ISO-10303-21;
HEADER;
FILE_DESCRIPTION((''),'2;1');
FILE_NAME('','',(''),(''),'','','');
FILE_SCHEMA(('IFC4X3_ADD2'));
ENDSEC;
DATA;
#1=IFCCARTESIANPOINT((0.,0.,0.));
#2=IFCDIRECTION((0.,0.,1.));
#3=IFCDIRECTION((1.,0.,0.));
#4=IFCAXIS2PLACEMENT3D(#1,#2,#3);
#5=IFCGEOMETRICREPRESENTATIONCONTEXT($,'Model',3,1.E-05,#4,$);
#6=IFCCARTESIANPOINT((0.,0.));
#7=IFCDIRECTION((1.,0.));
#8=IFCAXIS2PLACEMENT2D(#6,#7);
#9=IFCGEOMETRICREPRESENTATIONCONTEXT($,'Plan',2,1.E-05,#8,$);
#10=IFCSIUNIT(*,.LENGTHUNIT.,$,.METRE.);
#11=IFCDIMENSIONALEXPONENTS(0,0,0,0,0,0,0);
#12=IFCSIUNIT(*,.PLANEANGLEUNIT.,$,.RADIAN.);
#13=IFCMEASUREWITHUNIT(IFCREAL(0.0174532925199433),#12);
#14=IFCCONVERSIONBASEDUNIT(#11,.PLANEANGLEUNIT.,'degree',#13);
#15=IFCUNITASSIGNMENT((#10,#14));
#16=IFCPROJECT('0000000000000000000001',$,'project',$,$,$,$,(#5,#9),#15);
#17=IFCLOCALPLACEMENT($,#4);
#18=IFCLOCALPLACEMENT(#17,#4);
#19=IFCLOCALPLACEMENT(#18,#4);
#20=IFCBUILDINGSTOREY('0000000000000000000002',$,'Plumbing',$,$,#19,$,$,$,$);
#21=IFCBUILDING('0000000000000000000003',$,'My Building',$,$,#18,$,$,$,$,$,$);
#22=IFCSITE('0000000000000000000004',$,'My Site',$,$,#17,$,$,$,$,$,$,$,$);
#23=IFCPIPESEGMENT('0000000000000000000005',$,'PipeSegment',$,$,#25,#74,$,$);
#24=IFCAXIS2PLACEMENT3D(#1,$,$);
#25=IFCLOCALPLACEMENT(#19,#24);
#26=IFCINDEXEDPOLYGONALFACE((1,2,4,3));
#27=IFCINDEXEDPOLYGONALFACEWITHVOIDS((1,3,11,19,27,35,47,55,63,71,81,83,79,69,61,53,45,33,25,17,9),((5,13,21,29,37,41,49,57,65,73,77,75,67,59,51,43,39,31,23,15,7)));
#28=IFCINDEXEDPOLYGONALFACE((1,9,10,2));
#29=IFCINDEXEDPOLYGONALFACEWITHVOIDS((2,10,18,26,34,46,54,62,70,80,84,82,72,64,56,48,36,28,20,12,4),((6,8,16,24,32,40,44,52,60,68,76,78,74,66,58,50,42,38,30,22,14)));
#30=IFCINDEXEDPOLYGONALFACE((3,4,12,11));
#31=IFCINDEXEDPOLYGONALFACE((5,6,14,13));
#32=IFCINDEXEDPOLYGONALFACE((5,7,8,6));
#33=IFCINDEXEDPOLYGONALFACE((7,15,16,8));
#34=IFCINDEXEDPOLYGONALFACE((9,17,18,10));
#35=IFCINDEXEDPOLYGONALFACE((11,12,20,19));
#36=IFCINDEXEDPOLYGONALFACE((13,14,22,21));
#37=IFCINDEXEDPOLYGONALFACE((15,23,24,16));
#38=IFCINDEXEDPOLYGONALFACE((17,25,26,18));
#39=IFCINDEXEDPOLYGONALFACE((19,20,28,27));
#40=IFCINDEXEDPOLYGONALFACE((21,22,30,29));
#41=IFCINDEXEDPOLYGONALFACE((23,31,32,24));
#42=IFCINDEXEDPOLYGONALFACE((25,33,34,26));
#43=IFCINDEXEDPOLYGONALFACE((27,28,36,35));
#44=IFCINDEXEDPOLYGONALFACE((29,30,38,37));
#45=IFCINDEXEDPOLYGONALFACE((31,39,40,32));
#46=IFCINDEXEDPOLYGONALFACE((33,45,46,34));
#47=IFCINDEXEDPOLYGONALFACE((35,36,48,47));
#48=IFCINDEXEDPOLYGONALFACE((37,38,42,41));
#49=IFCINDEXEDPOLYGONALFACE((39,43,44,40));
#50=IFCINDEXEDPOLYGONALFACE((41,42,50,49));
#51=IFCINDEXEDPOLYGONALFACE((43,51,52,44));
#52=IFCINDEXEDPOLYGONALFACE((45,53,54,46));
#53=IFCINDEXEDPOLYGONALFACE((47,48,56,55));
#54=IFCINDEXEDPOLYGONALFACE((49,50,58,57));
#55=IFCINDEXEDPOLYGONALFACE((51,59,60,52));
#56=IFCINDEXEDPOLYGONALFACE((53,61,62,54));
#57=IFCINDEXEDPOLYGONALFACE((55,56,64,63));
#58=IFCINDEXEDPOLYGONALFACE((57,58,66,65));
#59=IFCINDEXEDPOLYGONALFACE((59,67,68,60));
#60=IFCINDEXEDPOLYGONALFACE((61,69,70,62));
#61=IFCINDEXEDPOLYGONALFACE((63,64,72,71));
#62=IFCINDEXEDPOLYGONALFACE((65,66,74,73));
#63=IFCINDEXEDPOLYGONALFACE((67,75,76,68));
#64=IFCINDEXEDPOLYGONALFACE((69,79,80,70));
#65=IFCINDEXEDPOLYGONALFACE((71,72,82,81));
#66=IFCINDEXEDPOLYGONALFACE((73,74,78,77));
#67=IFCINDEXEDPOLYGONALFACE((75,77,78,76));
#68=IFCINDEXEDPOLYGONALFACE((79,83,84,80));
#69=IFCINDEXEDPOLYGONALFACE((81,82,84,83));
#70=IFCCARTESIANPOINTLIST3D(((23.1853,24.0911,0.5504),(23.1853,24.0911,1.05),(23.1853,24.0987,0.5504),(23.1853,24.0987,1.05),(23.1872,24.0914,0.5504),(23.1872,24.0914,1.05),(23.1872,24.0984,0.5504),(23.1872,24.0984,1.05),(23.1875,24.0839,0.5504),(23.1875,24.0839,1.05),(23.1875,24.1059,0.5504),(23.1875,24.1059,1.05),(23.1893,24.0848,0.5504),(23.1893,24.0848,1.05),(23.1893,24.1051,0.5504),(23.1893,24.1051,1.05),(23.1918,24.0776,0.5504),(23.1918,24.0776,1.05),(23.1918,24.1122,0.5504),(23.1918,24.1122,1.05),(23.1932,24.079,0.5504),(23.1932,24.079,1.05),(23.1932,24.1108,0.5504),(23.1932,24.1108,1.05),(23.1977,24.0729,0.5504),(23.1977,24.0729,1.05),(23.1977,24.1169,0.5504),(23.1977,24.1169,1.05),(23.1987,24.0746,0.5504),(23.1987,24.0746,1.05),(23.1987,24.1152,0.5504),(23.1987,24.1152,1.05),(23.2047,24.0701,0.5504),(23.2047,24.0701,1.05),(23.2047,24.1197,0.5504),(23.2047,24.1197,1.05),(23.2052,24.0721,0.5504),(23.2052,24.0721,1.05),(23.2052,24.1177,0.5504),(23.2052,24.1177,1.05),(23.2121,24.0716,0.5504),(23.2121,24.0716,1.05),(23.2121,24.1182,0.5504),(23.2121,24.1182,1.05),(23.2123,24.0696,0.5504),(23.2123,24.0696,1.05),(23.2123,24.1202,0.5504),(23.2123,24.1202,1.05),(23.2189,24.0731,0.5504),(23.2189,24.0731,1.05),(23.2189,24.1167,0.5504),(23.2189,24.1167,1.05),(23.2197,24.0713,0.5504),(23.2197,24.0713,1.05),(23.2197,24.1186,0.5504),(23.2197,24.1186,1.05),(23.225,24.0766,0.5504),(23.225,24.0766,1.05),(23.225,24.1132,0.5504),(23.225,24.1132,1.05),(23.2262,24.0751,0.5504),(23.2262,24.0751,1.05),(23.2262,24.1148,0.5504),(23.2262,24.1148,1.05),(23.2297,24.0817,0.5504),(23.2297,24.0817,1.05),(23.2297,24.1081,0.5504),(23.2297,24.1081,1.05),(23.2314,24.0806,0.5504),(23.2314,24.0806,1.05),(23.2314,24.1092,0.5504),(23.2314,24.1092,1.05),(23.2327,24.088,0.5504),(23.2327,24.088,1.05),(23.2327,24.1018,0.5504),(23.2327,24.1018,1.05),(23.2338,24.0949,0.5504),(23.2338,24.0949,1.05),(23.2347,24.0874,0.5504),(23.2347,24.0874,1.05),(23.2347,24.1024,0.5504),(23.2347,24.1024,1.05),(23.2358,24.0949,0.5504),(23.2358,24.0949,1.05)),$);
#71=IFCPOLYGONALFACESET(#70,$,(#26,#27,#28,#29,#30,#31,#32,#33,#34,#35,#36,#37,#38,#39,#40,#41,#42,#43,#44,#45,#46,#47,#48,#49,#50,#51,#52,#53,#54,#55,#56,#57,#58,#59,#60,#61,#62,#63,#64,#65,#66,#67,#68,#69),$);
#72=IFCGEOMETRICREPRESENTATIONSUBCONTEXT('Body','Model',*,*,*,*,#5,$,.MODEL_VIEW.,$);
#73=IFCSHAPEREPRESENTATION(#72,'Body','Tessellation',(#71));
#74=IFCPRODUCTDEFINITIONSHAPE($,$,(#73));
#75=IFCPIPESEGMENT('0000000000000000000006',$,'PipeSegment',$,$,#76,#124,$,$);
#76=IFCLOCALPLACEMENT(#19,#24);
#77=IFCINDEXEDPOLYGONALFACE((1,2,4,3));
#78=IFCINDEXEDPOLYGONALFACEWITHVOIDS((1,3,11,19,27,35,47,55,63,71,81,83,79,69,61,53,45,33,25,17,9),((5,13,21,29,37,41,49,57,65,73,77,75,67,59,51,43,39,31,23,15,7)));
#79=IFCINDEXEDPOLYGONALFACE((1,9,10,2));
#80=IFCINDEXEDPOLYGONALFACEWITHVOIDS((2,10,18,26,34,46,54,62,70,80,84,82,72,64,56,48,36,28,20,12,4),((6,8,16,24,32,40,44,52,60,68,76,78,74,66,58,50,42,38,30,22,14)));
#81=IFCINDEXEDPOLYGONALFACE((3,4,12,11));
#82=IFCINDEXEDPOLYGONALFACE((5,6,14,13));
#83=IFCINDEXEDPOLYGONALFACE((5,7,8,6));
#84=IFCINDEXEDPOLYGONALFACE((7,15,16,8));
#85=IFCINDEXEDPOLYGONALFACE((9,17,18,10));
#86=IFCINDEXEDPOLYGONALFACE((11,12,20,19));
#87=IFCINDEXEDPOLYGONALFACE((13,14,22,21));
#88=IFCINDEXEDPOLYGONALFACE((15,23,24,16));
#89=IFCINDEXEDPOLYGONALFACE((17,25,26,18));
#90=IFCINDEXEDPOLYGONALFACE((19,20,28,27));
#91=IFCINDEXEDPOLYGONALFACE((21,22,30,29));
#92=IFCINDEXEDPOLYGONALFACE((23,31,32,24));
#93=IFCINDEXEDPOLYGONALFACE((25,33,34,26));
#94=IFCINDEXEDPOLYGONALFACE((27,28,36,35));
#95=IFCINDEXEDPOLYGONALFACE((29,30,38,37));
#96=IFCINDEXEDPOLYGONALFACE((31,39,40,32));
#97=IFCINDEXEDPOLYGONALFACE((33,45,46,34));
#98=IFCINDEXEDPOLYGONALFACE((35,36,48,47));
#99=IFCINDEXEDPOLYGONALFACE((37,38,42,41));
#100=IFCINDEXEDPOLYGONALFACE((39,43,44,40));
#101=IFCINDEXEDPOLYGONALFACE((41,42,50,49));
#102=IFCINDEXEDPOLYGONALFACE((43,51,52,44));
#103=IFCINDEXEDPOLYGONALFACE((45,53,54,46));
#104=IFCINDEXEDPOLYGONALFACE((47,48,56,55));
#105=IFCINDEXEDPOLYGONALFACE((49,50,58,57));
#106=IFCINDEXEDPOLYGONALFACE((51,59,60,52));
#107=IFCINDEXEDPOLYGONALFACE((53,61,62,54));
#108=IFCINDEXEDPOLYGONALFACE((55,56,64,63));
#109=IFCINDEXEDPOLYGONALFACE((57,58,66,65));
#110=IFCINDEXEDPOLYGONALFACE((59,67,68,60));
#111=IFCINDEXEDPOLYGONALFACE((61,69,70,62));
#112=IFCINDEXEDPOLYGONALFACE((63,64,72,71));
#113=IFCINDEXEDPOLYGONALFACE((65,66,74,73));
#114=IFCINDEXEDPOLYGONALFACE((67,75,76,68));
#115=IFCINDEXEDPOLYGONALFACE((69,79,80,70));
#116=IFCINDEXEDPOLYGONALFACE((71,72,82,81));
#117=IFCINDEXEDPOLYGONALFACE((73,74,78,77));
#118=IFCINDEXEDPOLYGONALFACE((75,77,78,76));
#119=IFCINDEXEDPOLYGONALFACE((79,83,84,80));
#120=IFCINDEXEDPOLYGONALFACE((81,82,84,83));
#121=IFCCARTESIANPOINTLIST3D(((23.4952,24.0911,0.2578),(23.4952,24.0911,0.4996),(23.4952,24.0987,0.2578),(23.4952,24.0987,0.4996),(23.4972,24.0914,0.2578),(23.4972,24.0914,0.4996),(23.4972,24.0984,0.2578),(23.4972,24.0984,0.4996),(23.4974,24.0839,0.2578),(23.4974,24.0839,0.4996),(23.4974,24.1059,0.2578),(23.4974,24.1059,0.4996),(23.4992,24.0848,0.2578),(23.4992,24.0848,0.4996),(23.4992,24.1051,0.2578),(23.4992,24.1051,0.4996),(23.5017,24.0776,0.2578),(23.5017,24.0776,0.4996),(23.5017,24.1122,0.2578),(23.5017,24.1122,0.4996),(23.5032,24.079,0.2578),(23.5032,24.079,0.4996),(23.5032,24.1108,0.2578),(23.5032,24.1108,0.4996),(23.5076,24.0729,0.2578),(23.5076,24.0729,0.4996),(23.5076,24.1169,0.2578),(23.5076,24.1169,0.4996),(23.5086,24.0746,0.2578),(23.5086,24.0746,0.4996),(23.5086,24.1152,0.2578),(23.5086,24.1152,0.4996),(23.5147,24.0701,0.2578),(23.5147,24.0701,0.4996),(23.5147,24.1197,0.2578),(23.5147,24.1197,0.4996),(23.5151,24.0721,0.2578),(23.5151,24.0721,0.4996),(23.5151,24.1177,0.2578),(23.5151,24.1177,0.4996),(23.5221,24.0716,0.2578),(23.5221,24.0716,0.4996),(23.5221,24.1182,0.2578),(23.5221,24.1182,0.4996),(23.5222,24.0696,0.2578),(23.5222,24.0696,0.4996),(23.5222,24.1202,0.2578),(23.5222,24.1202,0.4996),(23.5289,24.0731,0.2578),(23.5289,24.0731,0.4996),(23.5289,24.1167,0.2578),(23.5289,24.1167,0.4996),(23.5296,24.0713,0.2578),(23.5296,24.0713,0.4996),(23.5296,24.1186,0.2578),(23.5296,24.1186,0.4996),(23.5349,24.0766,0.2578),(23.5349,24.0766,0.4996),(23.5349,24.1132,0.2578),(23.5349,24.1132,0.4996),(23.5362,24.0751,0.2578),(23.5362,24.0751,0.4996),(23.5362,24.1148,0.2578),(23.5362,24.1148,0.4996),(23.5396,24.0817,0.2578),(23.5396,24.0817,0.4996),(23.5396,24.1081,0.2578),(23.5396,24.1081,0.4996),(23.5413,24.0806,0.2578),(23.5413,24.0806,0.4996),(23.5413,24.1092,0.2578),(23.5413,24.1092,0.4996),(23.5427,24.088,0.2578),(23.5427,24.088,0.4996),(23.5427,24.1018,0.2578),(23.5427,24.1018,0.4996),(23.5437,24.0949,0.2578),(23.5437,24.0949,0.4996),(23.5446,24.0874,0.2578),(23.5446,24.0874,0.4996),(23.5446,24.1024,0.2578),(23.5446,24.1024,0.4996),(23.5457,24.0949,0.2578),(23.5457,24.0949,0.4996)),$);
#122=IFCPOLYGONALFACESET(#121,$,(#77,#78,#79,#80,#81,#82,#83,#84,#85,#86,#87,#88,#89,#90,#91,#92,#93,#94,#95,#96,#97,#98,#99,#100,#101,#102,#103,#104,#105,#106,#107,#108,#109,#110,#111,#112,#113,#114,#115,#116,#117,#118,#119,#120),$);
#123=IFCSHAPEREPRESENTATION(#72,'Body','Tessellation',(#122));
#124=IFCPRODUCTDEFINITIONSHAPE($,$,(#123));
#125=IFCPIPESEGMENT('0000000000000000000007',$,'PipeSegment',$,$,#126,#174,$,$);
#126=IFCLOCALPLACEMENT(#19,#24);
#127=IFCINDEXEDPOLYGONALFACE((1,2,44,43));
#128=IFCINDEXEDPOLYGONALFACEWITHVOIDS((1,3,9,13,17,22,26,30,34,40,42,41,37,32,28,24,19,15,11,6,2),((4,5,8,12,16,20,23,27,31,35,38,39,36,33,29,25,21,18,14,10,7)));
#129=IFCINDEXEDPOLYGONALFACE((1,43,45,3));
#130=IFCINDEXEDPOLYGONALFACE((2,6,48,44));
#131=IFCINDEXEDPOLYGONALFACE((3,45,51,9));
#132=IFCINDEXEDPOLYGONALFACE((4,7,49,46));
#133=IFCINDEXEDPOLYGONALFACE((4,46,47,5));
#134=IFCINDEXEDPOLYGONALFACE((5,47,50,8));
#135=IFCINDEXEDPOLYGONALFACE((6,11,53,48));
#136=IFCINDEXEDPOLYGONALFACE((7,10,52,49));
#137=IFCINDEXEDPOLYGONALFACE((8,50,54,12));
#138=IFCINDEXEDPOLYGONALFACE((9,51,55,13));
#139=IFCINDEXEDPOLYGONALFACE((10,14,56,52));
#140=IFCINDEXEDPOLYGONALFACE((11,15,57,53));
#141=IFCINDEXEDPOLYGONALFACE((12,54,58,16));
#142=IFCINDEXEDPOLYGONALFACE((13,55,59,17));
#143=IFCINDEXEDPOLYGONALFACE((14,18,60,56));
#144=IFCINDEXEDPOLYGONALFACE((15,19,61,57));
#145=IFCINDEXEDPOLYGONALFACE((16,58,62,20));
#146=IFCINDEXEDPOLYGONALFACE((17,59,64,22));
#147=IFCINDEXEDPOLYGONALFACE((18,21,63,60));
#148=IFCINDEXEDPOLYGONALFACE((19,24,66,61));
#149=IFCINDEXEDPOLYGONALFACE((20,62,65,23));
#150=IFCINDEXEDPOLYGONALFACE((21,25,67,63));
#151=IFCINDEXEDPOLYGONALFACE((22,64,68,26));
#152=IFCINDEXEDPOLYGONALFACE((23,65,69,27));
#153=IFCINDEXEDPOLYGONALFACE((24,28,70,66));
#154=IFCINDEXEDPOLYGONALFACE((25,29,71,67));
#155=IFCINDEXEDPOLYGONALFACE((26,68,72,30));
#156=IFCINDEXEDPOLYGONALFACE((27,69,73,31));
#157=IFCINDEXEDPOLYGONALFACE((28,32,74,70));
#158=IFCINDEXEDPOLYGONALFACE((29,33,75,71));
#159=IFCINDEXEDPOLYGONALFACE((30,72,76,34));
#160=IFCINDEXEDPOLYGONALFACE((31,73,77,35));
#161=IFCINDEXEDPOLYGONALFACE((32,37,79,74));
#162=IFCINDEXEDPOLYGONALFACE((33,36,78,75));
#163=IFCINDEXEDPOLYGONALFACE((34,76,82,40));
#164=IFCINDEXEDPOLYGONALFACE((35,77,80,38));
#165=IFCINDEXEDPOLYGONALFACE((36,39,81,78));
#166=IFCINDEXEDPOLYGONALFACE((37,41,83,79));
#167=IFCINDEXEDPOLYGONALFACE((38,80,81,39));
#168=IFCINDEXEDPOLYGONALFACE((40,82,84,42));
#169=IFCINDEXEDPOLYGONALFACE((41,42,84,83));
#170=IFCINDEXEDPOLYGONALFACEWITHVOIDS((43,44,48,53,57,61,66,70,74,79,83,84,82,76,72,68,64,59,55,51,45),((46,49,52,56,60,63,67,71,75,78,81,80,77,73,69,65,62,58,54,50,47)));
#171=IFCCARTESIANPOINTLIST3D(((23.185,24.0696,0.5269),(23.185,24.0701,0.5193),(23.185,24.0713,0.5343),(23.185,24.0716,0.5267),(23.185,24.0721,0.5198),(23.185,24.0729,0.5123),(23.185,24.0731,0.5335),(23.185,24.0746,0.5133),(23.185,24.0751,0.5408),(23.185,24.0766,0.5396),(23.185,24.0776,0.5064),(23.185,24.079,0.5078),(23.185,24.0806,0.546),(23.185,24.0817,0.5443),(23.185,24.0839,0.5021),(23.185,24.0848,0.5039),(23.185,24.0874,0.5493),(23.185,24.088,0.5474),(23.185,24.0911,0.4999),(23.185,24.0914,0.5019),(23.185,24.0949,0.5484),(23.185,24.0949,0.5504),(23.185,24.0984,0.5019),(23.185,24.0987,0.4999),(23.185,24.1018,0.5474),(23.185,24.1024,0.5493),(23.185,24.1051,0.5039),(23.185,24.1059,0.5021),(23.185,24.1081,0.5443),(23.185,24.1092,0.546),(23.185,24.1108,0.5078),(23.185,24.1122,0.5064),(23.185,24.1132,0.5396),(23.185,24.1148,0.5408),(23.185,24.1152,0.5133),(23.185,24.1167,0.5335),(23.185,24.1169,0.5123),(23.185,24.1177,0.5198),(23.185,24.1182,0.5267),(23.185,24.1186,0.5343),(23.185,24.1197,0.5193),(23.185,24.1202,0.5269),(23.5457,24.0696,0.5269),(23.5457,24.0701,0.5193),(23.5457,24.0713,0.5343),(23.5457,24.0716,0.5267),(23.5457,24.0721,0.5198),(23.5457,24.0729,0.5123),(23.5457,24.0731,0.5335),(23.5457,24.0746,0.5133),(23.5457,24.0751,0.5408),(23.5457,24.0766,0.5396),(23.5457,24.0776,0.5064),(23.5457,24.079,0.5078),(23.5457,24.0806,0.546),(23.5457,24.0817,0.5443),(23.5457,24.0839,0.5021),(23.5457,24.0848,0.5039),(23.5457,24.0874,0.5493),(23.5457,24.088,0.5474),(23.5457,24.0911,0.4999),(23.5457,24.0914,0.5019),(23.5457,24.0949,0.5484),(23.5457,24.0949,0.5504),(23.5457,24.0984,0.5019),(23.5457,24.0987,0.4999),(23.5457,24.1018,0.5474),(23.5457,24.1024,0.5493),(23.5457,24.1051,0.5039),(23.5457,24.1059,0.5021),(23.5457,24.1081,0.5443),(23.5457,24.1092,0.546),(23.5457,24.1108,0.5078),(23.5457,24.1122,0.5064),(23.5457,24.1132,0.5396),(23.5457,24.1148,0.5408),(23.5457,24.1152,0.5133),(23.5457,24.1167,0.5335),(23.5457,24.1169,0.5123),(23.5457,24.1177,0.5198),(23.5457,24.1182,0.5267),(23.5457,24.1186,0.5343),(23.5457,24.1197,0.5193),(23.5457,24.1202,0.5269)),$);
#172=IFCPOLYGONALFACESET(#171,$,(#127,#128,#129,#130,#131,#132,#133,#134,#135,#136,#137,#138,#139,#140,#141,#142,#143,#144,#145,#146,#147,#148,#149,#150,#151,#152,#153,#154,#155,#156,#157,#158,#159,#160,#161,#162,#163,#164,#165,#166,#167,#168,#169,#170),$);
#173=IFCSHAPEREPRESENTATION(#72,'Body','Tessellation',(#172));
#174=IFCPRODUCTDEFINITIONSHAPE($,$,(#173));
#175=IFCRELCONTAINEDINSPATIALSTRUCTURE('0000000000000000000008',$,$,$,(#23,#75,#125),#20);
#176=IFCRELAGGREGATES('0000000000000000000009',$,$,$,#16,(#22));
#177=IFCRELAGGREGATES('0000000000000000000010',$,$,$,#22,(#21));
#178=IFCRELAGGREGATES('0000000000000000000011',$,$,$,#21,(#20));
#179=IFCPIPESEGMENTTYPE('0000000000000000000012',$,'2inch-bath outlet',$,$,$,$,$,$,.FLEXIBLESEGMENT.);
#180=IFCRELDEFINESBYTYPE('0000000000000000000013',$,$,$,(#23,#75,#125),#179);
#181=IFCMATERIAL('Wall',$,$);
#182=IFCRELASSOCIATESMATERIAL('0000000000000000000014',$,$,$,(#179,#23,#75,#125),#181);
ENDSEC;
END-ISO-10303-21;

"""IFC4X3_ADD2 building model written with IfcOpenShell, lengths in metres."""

from ifc_helpers import new_model, entity, si_unit, converted_unit, frame, origin_with_axes, origin_2d_with_axis, place, context, subcontext, project, spatial, hollow_circle, extrude, material, material_profile, profile_set, profile_usage, type_object, element, save


model = new_model("IFC4X3_ADD2")

# Units and contexts
model_context = context("Model", 3, precision=1e-05, world=origin_with_axes())
plan_context = context("Plan", 2, precision=1e-05, world=origin_2d_with_axis())
body_context = subcontext(model_context, "Body", "Model", "MODEL_VIEW")
ifc_project = project(units=[si_unit("LENGTHUNIT", "METRE"), converted_unit("PLANEANGLEUNIT", "degree", entity("IfcReal", 0.0174532925199433), si_unit("PLANEANGLEUNIT", "RADIAN"), dimensions=[0, 0, 0, 0, 0, 0, 0])], contexts=[model_context, plan_context])

# Site, building, storey
site_placement = place(None, origin_with_axes())
site = spatial("IfcSite", under=ifc_project, at=site_placement, Name="My Site")
building_placement = place(site_placement, origin_with_axes())
building = spatial("IfcBuilding", under=site, at=building_placement, Name="My Building")
storey_placement = place(building_placement, origin_with_axes())
storey = spatial("IfcBuildingStorey", under=building, at=storey_placement, Name="Plumbing")

# Pipe segments
ifc_material_1 = material(Name="Wall")
ifc_material_profile_1 = material_profile(ifc_material_1, hollow_circle(Radius=0.0254, WallThickness=0.002))
ifc_profile_set_1 = profile_set([ifc_material_profile_1], Name="graywater")
ifc_material_profile_2 = material_profile(ifc_material_1, hollow_circle(Radius=0.0254, WallThickness=0.002))
ifc_profile_set_2 = profile_set([ifc_material_profile_2], Name="graywater")
pipe_segment_type_1 = type_object("IfcPipeSegmentType", Name="2inch-bath outlet", PredefinedType="FLEXIBLESEGMENT", material=ifc_profile_set_2)
ifc_profile_usage_1 = profile_usage(ifc_profile_set_1)
pipe_segment_1_placement = place(storey_placement, frame((23.2104, 24.0949, 0.5504), z_axis=(0.0, 0.0, 1.0), x_axis=(1.0, 0.0, 0.0)))
element("IfcPipeSegment", 1, at=pipe_segment_1_placement, inside=storey, type_object=pipe_segment_type_1, material=ifc_profile_usage_1, Name="PipeSegment", context=body_context, shape_type="SweptSolid", body=[
    extrude(hollow_circle(Radius=0.0254, WallThickness=0.002), origin_with_axes(), (0.0, 0.0, 1.0), 0.4996),
])
ifc_profile_usage_2 = profile_usage(ifc_profile_set_1)
pipe_segment_2_placement = place(storey_placement, frame((23.5203, 24.0949, 0.2578), z_axis=(0.0, 0.0, 1.0), x_axis=(1.0, 0.0, 0.0)))
element("IfcPipeSegment", 2, at=pipe_segment_2_placement, inside=storey, type_object=pipe_segment_type_1, material=ifc_profile_usage_2, Name="PipeSegment", context=body_context, shape_type="SweptSolid", body=[
    extrude(hollow_circle(Radius=0.0254, WallThickness=0.002), origin_with_axes(), (0.0, 0.0, 1.0), 0.2418),
])
ifc_profile_usage_3 = profile_usage(ifc_profile_set_1)
pipe_segment_3_placement = place(storey_placement, frame((23.5457, 24.0949, 0.525), z_axis=(-1.0, 0.0, 0.0), x_axis=(0.0, 0.0, 1.0)))
element("IfcPipeSegment", 3, at=pipe_segment_3_placement, inside=storey, type_object=pipe_segment_type_1, material=ifc_profile_usage_3, Name="PipeSegment", context=body_context, shape_type="SweptSolid", body=[
    extrude(hollow_circle(Radius=0.0254, WallThickness=0.002), origin_with_axes(), (0.0, 0.0, 1.0), 0.3607),
])

save(model, "model.ifc")
